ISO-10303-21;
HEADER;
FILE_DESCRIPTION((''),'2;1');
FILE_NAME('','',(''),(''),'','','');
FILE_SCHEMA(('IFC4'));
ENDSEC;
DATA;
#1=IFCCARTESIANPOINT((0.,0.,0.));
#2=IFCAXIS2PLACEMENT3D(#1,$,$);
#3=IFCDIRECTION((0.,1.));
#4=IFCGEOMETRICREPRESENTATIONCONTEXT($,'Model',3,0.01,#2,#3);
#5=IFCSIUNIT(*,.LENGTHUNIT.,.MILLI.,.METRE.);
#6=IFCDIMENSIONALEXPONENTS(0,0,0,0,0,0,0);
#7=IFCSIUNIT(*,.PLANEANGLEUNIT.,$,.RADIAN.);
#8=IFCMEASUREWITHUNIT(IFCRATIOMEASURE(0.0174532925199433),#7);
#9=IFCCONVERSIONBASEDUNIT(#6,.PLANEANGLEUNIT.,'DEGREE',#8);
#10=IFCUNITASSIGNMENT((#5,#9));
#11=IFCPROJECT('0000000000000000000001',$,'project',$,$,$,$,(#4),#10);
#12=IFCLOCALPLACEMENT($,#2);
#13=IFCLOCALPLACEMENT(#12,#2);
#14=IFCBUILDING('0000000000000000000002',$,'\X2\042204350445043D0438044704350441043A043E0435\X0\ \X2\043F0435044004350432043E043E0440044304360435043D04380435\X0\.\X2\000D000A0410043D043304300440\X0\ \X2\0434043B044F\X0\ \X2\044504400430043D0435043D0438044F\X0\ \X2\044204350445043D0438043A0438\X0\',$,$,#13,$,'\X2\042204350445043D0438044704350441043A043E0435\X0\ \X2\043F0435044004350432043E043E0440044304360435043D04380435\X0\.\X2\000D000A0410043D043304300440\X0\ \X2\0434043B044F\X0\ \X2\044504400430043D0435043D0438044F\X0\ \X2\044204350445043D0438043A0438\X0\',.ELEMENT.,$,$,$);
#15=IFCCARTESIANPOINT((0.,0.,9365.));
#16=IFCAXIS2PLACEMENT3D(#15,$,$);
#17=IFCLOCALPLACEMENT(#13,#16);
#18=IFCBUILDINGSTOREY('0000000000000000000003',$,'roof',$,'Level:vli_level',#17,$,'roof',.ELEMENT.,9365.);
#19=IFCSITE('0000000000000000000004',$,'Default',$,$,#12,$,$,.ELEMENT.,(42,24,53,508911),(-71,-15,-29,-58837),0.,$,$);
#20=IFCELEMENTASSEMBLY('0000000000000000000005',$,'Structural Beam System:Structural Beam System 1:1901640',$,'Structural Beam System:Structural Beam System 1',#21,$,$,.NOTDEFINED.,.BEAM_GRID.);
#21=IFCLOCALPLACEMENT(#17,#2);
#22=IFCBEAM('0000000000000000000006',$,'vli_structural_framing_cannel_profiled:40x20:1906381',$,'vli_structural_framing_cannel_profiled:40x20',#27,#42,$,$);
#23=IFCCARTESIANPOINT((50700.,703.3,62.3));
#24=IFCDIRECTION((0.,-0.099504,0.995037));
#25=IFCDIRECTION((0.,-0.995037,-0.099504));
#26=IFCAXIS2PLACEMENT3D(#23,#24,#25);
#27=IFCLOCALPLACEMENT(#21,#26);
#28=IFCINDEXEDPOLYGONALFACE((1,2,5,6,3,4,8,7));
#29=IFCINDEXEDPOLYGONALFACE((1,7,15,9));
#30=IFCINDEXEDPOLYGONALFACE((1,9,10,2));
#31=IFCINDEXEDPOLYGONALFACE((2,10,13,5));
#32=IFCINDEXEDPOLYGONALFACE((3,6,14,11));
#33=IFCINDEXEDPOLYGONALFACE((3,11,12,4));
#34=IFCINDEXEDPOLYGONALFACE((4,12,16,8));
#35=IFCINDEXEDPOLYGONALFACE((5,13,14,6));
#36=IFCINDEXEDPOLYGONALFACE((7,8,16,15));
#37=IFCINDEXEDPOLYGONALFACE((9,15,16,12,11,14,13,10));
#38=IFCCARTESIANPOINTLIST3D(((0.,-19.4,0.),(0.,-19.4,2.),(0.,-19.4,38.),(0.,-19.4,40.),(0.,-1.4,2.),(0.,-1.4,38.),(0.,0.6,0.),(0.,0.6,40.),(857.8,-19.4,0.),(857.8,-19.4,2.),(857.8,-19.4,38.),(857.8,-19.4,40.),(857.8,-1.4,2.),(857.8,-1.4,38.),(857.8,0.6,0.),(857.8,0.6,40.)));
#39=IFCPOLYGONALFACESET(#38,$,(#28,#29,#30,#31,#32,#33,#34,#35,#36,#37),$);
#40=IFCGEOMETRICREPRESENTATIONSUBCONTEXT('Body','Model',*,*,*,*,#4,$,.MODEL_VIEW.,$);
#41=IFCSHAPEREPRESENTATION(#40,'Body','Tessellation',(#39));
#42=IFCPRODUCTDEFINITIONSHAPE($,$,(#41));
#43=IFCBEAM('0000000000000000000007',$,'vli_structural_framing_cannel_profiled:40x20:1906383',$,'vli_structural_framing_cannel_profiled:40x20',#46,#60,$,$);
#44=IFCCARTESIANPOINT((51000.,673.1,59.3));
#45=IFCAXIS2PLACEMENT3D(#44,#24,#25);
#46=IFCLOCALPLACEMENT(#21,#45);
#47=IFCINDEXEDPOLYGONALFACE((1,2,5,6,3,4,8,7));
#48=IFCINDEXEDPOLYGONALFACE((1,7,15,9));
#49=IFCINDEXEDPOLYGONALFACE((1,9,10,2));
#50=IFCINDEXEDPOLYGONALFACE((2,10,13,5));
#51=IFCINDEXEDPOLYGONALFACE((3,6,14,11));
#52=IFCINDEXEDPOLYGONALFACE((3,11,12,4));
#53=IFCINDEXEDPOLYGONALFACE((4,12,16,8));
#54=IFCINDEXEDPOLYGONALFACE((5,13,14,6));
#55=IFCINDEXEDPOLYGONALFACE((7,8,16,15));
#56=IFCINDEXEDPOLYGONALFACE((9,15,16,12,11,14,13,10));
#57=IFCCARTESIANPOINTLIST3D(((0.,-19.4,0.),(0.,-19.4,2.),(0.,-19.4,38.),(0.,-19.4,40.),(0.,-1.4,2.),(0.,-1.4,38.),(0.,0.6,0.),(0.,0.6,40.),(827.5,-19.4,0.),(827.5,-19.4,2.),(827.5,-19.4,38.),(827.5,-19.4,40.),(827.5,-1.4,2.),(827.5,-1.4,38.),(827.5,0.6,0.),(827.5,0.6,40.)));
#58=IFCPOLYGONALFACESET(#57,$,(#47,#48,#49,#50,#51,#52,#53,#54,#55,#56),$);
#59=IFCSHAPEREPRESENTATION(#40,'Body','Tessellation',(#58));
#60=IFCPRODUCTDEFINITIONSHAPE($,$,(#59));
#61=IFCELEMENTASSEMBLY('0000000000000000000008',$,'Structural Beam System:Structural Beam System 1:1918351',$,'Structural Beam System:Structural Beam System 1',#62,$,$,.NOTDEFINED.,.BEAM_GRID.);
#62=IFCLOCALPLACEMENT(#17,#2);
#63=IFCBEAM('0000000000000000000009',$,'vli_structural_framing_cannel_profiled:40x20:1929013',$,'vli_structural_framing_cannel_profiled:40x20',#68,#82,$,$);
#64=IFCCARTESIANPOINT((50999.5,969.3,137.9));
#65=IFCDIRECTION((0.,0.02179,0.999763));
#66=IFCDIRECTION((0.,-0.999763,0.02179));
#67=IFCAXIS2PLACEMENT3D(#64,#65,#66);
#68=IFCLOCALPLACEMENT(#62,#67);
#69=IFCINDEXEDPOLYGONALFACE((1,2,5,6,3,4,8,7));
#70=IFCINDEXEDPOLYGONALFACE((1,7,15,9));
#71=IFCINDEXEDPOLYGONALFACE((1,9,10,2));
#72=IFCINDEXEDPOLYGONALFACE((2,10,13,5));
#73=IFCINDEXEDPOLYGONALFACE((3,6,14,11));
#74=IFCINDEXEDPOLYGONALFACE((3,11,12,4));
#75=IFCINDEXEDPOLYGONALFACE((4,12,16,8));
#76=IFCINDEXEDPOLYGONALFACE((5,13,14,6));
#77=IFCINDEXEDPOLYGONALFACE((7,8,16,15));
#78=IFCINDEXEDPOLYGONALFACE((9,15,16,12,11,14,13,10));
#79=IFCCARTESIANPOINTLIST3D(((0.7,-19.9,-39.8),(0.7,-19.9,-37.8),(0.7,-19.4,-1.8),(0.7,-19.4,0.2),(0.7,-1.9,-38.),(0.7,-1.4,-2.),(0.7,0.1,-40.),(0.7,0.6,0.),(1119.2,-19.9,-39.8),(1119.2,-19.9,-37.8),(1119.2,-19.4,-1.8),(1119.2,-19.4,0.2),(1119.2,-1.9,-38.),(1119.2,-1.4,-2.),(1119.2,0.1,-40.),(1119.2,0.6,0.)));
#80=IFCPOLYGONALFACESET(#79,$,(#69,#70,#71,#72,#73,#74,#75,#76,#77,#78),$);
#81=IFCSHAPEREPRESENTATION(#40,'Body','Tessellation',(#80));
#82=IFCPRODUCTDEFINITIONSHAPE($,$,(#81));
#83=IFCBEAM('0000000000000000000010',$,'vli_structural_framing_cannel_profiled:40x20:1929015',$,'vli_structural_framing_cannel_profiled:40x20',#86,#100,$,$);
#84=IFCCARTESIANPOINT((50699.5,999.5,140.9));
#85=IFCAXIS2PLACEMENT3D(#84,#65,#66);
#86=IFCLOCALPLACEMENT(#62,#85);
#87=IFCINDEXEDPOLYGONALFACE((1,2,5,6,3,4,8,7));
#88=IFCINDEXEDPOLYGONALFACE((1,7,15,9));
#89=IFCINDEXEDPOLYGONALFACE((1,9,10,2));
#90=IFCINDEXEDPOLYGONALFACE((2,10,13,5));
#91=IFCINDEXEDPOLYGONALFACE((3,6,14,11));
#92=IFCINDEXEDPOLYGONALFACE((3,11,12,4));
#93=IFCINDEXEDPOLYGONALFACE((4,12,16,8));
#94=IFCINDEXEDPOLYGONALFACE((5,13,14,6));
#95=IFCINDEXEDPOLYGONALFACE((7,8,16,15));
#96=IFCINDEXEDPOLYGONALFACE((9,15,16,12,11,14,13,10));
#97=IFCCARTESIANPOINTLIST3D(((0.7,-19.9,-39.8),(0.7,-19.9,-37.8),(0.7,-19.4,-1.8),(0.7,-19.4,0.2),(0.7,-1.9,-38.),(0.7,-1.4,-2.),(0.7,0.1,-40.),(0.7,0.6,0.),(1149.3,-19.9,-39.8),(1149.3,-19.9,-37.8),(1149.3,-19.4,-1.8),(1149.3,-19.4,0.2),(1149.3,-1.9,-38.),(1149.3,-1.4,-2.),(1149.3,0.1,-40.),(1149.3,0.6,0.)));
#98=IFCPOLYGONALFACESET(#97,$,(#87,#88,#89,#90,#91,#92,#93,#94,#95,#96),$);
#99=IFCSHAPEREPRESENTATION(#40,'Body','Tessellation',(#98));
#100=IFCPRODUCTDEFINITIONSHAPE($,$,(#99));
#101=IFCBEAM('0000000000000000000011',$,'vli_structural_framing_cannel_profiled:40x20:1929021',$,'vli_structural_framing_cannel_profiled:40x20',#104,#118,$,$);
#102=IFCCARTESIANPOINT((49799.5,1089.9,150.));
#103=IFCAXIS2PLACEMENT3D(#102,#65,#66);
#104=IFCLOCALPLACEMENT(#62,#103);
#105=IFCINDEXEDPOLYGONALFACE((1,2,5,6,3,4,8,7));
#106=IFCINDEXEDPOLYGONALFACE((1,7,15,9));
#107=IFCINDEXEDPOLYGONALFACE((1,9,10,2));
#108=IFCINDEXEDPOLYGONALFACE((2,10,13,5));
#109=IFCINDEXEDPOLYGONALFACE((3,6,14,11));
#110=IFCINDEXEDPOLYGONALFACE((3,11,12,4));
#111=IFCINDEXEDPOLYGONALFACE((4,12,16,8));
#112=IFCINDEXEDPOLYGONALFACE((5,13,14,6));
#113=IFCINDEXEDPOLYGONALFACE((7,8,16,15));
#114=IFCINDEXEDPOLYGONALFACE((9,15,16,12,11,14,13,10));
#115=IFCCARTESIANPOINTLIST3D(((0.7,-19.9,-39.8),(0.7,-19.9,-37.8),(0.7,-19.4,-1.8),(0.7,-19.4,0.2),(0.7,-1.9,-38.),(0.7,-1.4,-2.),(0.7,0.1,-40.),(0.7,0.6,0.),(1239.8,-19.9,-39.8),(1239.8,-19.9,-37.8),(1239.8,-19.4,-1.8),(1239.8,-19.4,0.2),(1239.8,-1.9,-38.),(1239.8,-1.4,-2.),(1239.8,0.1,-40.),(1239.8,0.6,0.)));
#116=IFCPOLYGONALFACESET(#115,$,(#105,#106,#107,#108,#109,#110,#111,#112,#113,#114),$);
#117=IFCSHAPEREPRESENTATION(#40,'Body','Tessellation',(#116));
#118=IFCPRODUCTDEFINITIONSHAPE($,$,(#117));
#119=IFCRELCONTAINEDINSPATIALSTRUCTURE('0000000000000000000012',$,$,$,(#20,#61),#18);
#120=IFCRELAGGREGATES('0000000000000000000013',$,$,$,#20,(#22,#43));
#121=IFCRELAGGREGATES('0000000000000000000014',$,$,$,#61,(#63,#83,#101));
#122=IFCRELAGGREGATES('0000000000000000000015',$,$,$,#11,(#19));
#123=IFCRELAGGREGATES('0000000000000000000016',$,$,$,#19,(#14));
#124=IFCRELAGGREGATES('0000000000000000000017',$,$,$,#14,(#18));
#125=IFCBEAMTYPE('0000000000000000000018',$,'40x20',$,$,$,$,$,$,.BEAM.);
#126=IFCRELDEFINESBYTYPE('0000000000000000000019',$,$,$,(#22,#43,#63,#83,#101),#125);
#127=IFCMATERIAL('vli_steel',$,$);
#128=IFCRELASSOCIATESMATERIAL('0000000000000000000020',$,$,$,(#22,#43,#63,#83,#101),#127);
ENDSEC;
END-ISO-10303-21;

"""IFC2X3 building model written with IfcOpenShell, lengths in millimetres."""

from ifc_helpers import new_model, entity, si_unit, converted_unit, direction, frame, origin, place, context, subcontext, project, spatial, polyline, outline, extrude, material, type_object, element, aggregate, save


model = new_model("IFC2X3")

# Units and contexts
model_context = context("Model", 3, precision=0.01, world=origin(), true_north=direction((0.0, 1.0)))
body_context = subcontext(model_context, "Body", "Model", "MODEL_VIEW")
ifc_project = project(units=[si_unit("LENGTHUNIT", "METRE", prefix="MILLI"), converted_unit("PLANEANGLEUNIT", "DEGREE", entity("IfcRatioMeasure", 0.0174532925199433), si_unit("PLANEANGLEUNIT", "RADIAN"), dimensions=[0, 0, 0, 0, 0, 0, 0])], contexts=[model_context])

# Site, building, storey
site_placement = place(None, origin())
site = spatial("IfcSite", under=ifc_project, at=site_placement, Name="Default", CompositionType="ELEMENT", RefLatitude=(42, 24, 53, 508911), RefLongitude=(-71, -15, -29, -58837), RefElevation=0.0)
building_placement = place(site_placement, origin())
building = spatial("IfcBuilding", under=site, at=building_placement, Name="Техническое перевооружение.\r\nАнгар для хранения техники", LongName="Техническое перевооружение.\r\nАнгар для хранения техники", CompositionType="ELEMENT")
storey_placement = place(building_placement, frame((0.0, 0.0, 9365.0)))
storey = spatial("IfcBuildingStorey", under=building, at=storey_placement, Name="roof", ObjectType="Level:vli_level", LongName="roof", CompositionType="ELEMENT", Elevation=9365.0)

# Element assemblies, beams
assembly_1_placement = place(storey_placement, origin())
assembly_1 = element("IfcElementAssembly", 1, at=assembly_1_placement, inside=storey, Name="Structural Beam System:Structural Beam System 1:1901640", ObjectType="Structural Beam System:Structural Beam System 1", AssemblyPlace="NOTDEFINED", PredefinedType="BEAM_GRID")
ifc_material = material(Name="vli_steel")
beam_type = type_object("IfcBeamType", Name="40x20", PredefinedType="BEAM")
beam_1_placement = place(assembly_1_placement, frame((50700.0, 703.3, 62.3), z_axis=(0.0, -0.099504, 0.995037), x_axis=(0.0, -0.995037, -0.099504)))
beam_1 = element("IfcBeam", 2, at=beam_1_placement, type_object=beam_type, material=ifc_material, Name="vli_structural_framing_cannel_profiled:40x20:1906381", ObjectType="vli_structural_framing_cannel_profiled:40x20", context=body_context, shape_type="SweptSolid", body=[
    extrude(outline(polyline([(-20.0, -9.5), (-18.0, -9.5), (-18.0, 8.5), (18.0, 8.5), (18.0, -9.5), (20.0, -9.5), (20.0, 10.5), (-20.0, 10.5), (-20.0, -9.5)])), frame((0.0, -9.9, 20.0), z_axis=(1.0, 0.0, 0.0), x_axis=(0.0, 0.0, -1.0)), (0.0, 0.0, 1.0), 857.8),
])
beam_2_placement = place(assembly_1_placement, frame((51000.0, 673.1, 59.3), z_axis=(0.0, -0.099504, 0.995037), x_axis=(0.0, -0.995037, -0.099504)))
beam_2 = element("IfcBeam", 3, at=beam_2_placement, type_object=beam_type, material=ifc_material, Name="vli_structural_framing_cannel_profiled:40x20:1906383", ObjectType="vli_structural_framing_cannel_profiled:40x20", context=body_context, shape_type="SweptSolid", body=[
    extrude(outline(polyline([(-20.0, -9.5), (-18.0, -9.5), (-18.0, 8.5), (18.0, 8.5), (18.0, -9.5), (20.0, -9.5), (20.0, 10.5), (-20.0, 10.5), (-20.0, -9.5)])), frame((0.0, -9.9, 20.0), z_axis=(1.0, 0.0, 0.0), x_axis=(0.0, 0.0, -1.0)), (0.0, 0.0, 1.0), 827.5),
])
aggregate(assembly_1, [beam_1, beam_2])
assembly_2_placement = place(storey_placement, origin())
assembly_2 = element("IfcElementAssembly", 4, at=assembly_2_placement, inside=storey, Name="Structural Beam System:Structural Beam System 1:1918351", ObjectType="Structural Beam System:Structural Beam System 1", AssemblyPlace="NOTDEFINED", PredefinedType="BEAM_GRID")
beam_3_placement = place(assembly_2_placement, frame((50999.5, 969.3, 137.9), z_axis=(0.0, 0.02179, 0.999763), x_axis=(0.0, -0.999763, 0.02179)))
beam_3 = element("IfcBeam", 5, at=beam_3_placement, type_object=beam_type, material=ifc_material, Name="vli_structural_framing_cannel_profiled:40x20:1929013", ObjectType="vli_structural_framing_cannel_profiled:40x20", context=body_context, shape_type="SweptSolid", body=[
    extrude(outline(polyline([(-10.5, -20.0), (9.5, -20.0), (9.5, -18.0), (-8.5, -18.0), (-8.5, 18.0), (9.5, 18.0), (9.5, 20.0), (-10.5, 20.0), (-10.5, -20.0)])), frame((0.7, -10.1, -19.9), z_axis=(1.0, 0.0, 0.0), x_axis=(0.0, -0.999925, 0.012243)), (0.0, 0.0, 1.0), 1118.5),
])
beam_4_placement = place(assembly_2_placement, frame((50699.5, 999.5, 140.9), z_axis=(0.0, 0.02179, 0.999763), x_axis=(0.0, -0.999763, 0.02179)))
beam_4 = element("IfcBeam", 6, at=beam_4_placement, type_object=beam_type, material=ifc_material, Name="vli_structural_framing_cannel_profiled:40x20:1929015", ObjectType="vli_structural_framing_cannel_profiled:40x20", context=body_context, shape_type="SweptSolid", body=[
    extrude(outline(polyline([(-10.5, -20.0), (9.5, -20.0), (9.5, -18.0), (-8.5, -18.0), (-8.5, 18.0), (9.5, 18.0), (9.5, 20.0), (-10.5, 20.0), (-10.5, -20.0)])), frame((0.7, -10.1, -19.9), z_axis=(1.0, 0.0, 0.0), x_axis=(0.0, -0.999925, 0.012243)), (0.0, 0.0, 1.0), 1148.7),
])
beam_5_placement = place(assembly_2_placement, frame((49799.5, 1089.9, 150.0), z_axis=(0.0, 0.02179, 0.999763), x_axis=(0.0, -0.999763, 0.02179)))
beam_5 = element("IfcBeam", 7, at=beam_5_placement, type_object=beam_type, material=ifc_material, Name="vli_structural_framing_cannel_profiled:40x20:1929021", ObjectType="vli_structural_framing_cannel_profiled:40x20", context=body_context, shape_type="SweptSolid", body=[
    extrude(outline(polyline([(-10.5, -20.0), (9.5, -20.0), (9.5, -18.0), (-8.5, -18.0), (-8.5, 18.0), (9.5, 18.0), (9.5, 20.0), (-10.5, 20.0), (-10.5, -20.0)])), frame((0.7, -10.1, -19.9), z_axis=(1.0, 0.0, 0.0), x_axis=(0.0, -0.999925, 0.012243)), (0.0, 0.0, 1.0), 1239.1),
])
aggregate(assembly_2, [beam_3, beam_4, beam_5])

save(model, "model.ifc")
